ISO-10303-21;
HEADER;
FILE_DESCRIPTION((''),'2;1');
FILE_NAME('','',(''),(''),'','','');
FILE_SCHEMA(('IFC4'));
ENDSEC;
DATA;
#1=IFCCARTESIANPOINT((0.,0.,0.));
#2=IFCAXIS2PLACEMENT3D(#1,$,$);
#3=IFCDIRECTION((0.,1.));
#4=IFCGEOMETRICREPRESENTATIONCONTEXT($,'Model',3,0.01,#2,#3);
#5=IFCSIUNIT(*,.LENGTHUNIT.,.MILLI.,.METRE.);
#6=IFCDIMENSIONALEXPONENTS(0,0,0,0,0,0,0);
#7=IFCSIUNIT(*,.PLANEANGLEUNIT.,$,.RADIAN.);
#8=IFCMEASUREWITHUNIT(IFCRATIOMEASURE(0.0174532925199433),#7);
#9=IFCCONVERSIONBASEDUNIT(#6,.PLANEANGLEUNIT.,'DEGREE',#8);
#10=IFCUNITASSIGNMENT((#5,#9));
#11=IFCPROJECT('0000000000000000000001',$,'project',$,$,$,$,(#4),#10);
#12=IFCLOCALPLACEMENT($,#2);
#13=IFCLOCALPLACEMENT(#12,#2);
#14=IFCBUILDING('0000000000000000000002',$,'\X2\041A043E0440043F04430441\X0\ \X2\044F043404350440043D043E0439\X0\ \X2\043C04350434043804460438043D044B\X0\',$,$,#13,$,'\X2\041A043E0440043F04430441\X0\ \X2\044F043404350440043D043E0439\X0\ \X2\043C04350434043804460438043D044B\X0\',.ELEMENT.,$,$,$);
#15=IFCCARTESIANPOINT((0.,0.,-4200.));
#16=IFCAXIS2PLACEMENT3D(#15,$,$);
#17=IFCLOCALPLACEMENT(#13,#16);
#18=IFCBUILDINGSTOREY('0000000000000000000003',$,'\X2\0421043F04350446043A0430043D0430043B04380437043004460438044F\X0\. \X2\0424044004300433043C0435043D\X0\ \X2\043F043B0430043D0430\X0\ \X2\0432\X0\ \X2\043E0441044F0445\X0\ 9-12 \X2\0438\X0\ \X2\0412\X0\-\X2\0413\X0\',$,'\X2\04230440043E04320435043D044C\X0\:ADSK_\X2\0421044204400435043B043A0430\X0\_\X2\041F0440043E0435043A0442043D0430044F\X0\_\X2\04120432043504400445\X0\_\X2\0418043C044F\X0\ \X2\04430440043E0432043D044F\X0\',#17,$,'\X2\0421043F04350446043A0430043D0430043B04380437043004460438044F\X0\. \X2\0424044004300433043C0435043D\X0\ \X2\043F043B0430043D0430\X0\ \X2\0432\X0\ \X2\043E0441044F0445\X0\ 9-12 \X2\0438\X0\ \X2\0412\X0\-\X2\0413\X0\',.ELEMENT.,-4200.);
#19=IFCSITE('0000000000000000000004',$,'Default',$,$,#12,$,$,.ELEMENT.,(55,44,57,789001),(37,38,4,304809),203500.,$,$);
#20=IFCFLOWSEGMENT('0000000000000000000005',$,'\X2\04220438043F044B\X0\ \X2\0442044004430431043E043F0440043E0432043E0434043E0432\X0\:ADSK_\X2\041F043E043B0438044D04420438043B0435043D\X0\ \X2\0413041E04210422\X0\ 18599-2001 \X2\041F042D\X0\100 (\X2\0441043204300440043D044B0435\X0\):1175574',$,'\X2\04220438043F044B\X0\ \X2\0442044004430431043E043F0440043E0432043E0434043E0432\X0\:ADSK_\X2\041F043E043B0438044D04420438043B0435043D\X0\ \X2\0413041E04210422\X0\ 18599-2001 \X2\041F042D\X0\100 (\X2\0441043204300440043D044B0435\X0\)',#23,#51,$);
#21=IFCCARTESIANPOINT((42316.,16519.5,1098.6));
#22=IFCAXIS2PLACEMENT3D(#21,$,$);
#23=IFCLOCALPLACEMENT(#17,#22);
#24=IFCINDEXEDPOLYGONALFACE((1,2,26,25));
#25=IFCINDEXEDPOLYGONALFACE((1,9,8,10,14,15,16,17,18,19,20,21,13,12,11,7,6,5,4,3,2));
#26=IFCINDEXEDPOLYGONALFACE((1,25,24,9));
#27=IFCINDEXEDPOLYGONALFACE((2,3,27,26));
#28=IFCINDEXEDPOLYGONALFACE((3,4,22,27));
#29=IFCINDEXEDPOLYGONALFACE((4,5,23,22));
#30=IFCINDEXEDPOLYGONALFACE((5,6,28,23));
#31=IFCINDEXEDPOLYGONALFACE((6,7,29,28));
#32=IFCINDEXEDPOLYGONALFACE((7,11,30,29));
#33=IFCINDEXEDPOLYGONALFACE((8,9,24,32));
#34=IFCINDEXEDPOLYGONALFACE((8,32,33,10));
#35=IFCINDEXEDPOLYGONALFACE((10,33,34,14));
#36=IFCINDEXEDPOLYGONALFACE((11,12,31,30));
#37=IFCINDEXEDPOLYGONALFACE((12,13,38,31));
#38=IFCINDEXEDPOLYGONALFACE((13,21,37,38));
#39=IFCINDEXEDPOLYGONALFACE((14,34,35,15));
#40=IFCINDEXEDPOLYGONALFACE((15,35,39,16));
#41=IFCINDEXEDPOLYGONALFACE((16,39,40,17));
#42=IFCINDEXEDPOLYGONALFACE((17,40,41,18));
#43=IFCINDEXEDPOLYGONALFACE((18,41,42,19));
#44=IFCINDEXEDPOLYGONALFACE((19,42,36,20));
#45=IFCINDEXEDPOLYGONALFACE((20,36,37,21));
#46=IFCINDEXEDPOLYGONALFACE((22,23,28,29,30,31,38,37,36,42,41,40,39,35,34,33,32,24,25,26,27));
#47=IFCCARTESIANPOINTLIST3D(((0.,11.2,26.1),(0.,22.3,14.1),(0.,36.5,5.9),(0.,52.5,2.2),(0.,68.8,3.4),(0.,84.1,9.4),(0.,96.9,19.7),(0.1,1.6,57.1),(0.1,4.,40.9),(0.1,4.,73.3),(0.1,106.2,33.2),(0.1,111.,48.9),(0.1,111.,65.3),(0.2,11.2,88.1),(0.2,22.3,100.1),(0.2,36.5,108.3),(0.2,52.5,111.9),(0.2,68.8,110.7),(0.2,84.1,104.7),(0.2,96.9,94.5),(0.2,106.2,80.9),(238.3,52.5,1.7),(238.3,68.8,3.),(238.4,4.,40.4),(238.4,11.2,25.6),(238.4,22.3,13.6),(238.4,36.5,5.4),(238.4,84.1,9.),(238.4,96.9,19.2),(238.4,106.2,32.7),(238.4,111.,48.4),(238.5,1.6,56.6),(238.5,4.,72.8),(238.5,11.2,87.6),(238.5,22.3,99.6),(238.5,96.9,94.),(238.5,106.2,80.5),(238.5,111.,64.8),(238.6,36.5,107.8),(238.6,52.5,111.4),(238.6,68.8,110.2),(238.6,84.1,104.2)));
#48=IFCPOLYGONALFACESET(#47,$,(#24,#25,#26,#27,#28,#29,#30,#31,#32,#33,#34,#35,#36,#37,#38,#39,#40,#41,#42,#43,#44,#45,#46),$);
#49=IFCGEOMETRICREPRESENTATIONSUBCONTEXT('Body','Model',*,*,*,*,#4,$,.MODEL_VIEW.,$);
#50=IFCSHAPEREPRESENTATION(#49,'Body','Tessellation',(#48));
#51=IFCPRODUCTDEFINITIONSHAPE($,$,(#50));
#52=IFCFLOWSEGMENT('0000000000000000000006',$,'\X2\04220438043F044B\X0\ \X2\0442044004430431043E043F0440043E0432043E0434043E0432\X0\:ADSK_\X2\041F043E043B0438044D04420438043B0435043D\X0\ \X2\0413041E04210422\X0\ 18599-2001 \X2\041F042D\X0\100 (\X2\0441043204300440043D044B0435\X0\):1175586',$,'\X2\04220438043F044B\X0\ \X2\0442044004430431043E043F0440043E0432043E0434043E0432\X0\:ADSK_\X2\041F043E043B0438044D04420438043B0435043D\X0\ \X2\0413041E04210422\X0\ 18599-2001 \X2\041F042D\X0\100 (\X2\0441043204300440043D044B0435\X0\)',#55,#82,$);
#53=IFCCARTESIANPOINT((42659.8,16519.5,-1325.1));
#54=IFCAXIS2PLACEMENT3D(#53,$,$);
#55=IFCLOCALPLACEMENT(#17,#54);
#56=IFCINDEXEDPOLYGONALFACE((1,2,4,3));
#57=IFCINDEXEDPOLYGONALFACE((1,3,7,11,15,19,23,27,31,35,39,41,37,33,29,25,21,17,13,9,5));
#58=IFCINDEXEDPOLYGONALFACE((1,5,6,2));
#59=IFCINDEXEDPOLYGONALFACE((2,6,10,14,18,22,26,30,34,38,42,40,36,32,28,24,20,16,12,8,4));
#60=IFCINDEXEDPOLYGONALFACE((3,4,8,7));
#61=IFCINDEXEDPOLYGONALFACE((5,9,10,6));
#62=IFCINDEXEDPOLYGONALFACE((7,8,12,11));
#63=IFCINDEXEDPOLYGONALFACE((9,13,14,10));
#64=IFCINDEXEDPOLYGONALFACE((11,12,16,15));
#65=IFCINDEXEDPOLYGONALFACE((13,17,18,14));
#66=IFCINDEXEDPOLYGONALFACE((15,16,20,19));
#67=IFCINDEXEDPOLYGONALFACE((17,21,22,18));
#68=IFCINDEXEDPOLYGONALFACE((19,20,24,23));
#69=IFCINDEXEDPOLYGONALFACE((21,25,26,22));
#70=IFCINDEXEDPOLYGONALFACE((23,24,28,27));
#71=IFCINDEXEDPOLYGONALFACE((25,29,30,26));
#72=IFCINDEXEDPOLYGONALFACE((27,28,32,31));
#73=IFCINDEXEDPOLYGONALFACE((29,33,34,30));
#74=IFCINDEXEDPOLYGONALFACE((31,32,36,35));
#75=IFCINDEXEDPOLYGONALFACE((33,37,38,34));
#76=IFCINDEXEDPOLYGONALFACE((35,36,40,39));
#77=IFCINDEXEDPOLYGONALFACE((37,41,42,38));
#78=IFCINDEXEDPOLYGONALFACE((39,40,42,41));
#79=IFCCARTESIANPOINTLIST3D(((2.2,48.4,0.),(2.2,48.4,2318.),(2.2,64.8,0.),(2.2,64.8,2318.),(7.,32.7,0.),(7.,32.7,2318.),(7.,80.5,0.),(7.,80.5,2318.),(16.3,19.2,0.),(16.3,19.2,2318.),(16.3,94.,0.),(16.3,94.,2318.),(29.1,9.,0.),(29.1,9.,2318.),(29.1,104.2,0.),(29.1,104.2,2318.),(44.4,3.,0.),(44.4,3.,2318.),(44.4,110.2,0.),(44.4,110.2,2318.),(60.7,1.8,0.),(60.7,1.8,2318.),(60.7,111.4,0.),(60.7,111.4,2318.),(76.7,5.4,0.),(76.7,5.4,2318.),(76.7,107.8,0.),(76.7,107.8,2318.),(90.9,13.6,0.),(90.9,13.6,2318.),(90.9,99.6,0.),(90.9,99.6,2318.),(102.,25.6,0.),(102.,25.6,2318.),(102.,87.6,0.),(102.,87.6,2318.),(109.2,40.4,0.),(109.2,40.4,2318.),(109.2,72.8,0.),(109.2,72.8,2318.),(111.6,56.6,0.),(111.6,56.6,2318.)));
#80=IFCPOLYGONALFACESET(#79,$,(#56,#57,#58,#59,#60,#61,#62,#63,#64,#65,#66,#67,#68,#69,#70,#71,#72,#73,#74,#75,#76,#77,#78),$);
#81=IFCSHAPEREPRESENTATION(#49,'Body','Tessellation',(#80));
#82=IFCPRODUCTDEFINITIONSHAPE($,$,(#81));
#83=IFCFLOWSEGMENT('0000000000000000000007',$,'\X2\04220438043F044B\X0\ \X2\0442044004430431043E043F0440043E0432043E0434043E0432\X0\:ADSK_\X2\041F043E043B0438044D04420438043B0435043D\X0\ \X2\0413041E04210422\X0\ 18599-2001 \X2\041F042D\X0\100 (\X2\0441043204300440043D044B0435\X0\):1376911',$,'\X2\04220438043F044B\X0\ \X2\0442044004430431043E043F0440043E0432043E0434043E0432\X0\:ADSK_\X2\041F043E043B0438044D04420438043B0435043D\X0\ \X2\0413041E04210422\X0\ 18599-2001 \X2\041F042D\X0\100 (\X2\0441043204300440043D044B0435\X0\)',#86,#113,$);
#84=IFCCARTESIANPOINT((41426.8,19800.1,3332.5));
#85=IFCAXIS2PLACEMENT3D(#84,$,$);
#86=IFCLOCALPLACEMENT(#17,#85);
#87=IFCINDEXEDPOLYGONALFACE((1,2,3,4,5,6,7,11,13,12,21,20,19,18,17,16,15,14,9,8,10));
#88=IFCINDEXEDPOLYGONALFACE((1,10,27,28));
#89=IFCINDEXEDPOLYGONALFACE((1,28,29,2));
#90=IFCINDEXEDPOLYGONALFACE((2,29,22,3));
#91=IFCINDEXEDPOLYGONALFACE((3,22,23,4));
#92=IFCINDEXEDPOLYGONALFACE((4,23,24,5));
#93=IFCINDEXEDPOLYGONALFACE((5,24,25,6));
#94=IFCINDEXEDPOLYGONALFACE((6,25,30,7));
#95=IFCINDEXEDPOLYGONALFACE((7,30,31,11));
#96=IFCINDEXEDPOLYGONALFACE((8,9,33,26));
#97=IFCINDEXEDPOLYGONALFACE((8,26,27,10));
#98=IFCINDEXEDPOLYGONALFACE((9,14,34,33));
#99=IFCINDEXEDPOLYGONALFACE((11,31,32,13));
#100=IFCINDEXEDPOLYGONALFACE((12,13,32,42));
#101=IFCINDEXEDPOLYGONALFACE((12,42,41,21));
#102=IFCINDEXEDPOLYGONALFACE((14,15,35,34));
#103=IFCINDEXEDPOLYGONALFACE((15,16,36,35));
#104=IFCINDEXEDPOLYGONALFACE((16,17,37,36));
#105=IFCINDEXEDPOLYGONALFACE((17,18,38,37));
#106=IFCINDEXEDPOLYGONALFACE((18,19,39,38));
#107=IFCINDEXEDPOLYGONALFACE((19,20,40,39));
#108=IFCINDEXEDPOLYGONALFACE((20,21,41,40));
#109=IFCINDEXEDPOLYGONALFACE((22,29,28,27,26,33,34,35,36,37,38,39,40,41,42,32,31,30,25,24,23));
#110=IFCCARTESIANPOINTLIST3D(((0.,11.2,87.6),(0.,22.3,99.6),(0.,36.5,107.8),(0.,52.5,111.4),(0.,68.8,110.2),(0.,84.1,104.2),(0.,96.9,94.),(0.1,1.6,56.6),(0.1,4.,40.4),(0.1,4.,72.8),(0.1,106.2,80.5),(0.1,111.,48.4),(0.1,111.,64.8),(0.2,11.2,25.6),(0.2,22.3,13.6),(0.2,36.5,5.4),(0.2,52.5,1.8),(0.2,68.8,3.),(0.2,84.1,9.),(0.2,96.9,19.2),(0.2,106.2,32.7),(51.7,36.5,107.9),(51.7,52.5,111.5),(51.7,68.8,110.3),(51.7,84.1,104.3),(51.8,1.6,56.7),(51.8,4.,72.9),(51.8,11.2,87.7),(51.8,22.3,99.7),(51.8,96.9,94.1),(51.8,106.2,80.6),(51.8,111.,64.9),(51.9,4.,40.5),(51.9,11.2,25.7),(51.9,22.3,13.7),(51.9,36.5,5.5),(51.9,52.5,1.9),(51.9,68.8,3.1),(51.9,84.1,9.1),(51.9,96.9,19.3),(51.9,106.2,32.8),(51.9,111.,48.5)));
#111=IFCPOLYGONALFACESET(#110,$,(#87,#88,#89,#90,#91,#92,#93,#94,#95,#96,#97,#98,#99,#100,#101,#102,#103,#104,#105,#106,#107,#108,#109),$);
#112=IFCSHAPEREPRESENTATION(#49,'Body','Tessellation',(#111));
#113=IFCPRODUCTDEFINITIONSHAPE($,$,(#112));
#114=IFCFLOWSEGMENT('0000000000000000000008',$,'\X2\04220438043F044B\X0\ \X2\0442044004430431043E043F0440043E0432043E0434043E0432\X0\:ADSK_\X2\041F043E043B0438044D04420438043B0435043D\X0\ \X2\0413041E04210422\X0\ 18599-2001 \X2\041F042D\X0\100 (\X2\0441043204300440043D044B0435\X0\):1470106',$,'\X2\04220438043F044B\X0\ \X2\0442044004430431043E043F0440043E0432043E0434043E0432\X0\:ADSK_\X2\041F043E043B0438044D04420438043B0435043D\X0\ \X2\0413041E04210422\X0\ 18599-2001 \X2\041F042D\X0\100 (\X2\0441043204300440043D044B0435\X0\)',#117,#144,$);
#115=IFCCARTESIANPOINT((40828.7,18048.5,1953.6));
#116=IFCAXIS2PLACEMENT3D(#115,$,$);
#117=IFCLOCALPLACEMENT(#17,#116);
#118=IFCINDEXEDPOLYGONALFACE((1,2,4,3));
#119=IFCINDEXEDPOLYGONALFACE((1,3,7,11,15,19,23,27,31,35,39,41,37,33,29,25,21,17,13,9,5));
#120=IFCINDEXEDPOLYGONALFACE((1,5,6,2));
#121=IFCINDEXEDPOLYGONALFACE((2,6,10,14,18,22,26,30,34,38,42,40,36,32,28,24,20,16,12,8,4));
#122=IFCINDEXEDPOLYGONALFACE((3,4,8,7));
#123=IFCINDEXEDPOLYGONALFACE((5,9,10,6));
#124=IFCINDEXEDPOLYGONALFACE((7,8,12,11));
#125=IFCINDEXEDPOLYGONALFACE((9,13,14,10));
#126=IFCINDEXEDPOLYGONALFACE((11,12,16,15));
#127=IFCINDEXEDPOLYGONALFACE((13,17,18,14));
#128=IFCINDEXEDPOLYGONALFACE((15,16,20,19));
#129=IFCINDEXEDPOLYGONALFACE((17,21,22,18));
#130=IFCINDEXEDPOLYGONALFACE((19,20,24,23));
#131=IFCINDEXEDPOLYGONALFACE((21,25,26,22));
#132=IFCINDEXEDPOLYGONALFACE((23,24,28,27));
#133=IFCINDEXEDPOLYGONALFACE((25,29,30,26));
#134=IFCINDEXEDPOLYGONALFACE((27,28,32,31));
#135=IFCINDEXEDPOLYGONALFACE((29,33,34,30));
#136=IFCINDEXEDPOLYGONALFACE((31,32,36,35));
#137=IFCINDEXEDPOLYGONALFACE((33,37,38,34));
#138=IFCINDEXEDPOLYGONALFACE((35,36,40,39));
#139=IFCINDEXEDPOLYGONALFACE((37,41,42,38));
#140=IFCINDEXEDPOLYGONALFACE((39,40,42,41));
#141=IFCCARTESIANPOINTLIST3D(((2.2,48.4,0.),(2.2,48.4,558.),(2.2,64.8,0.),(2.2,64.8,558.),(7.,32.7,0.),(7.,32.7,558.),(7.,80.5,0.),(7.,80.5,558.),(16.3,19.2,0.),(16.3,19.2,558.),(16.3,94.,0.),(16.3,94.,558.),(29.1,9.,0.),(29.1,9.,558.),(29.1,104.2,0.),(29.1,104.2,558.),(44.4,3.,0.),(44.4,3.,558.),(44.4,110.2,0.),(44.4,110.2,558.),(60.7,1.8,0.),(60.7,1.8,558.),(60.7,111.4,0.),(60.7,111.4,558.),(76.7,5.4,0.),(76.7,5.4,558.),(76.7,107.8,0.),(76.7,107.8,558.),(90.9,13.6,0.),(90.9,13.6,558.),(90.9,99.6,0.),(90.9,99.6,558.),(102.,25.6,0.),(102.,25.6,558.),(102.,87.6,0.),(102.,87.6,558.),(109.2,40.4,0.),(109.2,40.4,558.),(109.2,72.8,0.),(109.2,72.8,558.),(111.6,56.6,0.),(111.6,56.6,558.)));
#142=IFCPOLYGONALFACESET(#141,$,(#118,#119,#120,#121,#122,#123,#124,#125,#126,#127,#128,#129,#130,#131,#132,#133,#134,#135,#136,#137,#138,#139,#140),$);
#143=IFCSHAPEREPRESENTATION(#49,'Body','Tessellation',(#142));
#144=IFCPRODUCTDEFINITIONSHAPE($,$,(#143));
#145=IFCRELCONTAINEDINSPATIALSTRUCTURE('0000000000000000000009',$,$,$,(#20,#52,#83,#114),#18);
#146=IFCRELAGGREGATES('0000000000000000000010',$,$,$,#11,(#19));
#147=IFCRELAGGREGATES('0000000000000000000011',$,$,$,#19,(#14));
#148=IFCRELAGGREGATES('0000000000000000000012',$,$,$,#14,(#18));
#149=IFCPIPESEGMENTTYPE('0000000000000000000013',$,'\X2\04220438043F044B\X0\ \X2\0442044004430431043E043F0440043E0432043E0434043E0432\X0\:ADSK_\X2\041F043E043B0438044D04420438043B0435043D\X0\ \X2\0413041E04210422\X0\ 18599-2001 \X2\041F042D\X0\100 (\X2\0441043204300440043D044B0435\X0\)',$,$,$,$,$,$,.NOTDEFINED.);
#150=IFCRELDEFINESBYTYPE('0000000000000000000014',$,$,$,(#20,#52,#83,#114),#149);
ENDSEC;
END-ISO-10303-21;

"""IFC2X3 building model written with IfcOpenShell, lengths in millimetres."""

from ifc_helpers import new_model, entity, si_unit, converted_unit, direction, frame, origin, origin_2d_with_axis, place, context, subcontext, project, spatial, circle, extrude, type_object, element, save


model = new_model("IFC2X3")

# Units and contexts
model_context = context("Model", 3, precision=0.01, world=origin(), true_north=direction((0.0, 1.0)))
body_context = subcontext(model_context, "Body", "Model", "MODEL_VIEW")
ifc_project = project(units=[si_unit("LENGTHUNIT", "METRE", prefix="MILLI"), converted_unit("PLANEANGLEUNIT", "DEGREE", entity("IfcRatioMeasure", 0.0174532925199433), si_unit("PLANEANGLEUNIT", "RADIAN"), dimensions=[0, 0, 0, 0, 0, 0, 0])], contexts=[model_context])

# Site, building, storey
site_placement = place(None, origin())
site = spatial("IfcSite", under=ifc_project, at=site_placement, Name="Default", CompositionType="ELEMENT", RefLatitude=(55, 44, 57, 789001), RefLongitude=(37, 38, 4, 304809), RefElevation=203500.0)
building_placement = place(site_placement, origin())
building = spatial("IfcBuilding", under=site, at=building_placement, Name="Корпус ядерной медицины", LongName="Корпус ядерной медицины", CompositionType="ELEMENT")
storey_placement = place(building_placement, frame((0.0, 0.0, -4200.0)))
storey = spatial("IfcBuildingStorey", under=building, at=storey_placement, Name="Спецканализация. Фрагмен плана в осях 9-12 и В-Г", ObjectType="Уровень:ADSK_Стрелка_Проектная_Вверх_Имя уровня", LongName="Спецканализация. Фрагмен плана в осях 9-12 и В-Г", CompositionType="ELEMENT", Elevation=-4200.0)

# Flow segments
pipe_segment_type = type_object("IfcPipeSegmentType", Name="Типы трубопроводов:ADSK_Полиэтилен ГОСТ 18599-2001 ПЭ100 (сварные)", PredefinedType="NOTDEFINED")
flow_segment_1_placement = place(storey_placement, frame((42316.0, 16519.5, 1098.6)))
element("IfcFlowSegment", 1, at=flow_segment_1_placement, inside=storey, type_object=pipe_segment_type, Name="Типы трубопроводов:ADSK_Полиэтилен ГОСТ 18599-2001 ПЭ100 (сварные):1175574", ObjectType="Типы трубопроводов:ADSK_Полиэтилен ГОСТ 18599-2001 ПЭ100 (сварные)", context=body_context, shape_type="SweptSolid", body=[
    extrude(circle(Radius=55.0, at=origin_2d_with_axis()), frame((0.1, 56.6, 57.1), z_axis=(0.999998, 0.0, -0.002), x_axis=(0.0, -1.0, 0.0)), (0.0, 0.0, 1.0), 238.3),
])
flow_segment_2_placement = place(storey_placement, frame((42659.8, 16519.5, -1325.1)))
element("IfcFlowSegment", 2, at=flow_segment_2_placement, inside=storey, type_object=pipe_segment_type, Name="Типы трубопроводов:ADSK_Полиэтилен ГОСТ 18599-2001 ПЭ100 (сварные):1175586", ObjectType="Типы трубопроводов:ADSK_Полиэтилен ГОСТ 18599-2001 ПЭ100 (сварные)", context=body_context, shape_type="SweptSolid", body=[
    extrude(circle(Radius=55.0, at=origin_2d_with_axis()), frame((56.6, 56.6, 0.0)), (0.0, 0.0, 1.0), 2318.0),
])
flow_segment_3_placement = place(storey_placement, frame((41426.8, 19800.1, 3332.5)))
element("IfcFlowSegment", 3, at=flow_segment_3_placement, inside=storey, type_object=pipe_segment_type, Name="Типы трубопроводов:ADSK_Полиэтилен ГОСТ 18599-2001 ПЭ100 (сварные):1376911", ObjectType="Типы трубопроводов:ADSK_Полиэтилен ГОСТ 18599-2001 ПЭ100 (сварные)", context=body_context, shape_type="SweptSolid", body=[
    extrude(circle(Radius=55.0, at=origin_2d_with_axis()), frame((0.1, 56.6, 56.6), z_axis=(0.999998, 0.0, 0.002), x_axis=(0.0, -1.0, 0.0)), (0.0, 0.0, 1.0), 51.7),
])
flow_segment_4_placement = place(storey_placement, frame((40828.7, 18048.5, 1953.6)))
element("IfcFlowSegment", 4, at=flow_segment_4_placement, inside=storey, type_object=pipe_segment_type, Name="Типы трубопроводов:ADSK_Полиэтилен ГОСТ 18599-2001 ПЭ100 (сварные):1470106", ObjectType="Типы трубопроводов:ADSK_Полиэтилен ГОСТ 18599-2001 ПЭ100 (сварные)", context=body_context, shape_type="SweptSolid", body=[
    extrude(circle(Radius=55.0, at=origin_2d_with_axis()), frame((56.6, 56.6, 0.0)), (0.0, 0.0, 1.0), 558.0),
])

save(model, "model.ifc")
